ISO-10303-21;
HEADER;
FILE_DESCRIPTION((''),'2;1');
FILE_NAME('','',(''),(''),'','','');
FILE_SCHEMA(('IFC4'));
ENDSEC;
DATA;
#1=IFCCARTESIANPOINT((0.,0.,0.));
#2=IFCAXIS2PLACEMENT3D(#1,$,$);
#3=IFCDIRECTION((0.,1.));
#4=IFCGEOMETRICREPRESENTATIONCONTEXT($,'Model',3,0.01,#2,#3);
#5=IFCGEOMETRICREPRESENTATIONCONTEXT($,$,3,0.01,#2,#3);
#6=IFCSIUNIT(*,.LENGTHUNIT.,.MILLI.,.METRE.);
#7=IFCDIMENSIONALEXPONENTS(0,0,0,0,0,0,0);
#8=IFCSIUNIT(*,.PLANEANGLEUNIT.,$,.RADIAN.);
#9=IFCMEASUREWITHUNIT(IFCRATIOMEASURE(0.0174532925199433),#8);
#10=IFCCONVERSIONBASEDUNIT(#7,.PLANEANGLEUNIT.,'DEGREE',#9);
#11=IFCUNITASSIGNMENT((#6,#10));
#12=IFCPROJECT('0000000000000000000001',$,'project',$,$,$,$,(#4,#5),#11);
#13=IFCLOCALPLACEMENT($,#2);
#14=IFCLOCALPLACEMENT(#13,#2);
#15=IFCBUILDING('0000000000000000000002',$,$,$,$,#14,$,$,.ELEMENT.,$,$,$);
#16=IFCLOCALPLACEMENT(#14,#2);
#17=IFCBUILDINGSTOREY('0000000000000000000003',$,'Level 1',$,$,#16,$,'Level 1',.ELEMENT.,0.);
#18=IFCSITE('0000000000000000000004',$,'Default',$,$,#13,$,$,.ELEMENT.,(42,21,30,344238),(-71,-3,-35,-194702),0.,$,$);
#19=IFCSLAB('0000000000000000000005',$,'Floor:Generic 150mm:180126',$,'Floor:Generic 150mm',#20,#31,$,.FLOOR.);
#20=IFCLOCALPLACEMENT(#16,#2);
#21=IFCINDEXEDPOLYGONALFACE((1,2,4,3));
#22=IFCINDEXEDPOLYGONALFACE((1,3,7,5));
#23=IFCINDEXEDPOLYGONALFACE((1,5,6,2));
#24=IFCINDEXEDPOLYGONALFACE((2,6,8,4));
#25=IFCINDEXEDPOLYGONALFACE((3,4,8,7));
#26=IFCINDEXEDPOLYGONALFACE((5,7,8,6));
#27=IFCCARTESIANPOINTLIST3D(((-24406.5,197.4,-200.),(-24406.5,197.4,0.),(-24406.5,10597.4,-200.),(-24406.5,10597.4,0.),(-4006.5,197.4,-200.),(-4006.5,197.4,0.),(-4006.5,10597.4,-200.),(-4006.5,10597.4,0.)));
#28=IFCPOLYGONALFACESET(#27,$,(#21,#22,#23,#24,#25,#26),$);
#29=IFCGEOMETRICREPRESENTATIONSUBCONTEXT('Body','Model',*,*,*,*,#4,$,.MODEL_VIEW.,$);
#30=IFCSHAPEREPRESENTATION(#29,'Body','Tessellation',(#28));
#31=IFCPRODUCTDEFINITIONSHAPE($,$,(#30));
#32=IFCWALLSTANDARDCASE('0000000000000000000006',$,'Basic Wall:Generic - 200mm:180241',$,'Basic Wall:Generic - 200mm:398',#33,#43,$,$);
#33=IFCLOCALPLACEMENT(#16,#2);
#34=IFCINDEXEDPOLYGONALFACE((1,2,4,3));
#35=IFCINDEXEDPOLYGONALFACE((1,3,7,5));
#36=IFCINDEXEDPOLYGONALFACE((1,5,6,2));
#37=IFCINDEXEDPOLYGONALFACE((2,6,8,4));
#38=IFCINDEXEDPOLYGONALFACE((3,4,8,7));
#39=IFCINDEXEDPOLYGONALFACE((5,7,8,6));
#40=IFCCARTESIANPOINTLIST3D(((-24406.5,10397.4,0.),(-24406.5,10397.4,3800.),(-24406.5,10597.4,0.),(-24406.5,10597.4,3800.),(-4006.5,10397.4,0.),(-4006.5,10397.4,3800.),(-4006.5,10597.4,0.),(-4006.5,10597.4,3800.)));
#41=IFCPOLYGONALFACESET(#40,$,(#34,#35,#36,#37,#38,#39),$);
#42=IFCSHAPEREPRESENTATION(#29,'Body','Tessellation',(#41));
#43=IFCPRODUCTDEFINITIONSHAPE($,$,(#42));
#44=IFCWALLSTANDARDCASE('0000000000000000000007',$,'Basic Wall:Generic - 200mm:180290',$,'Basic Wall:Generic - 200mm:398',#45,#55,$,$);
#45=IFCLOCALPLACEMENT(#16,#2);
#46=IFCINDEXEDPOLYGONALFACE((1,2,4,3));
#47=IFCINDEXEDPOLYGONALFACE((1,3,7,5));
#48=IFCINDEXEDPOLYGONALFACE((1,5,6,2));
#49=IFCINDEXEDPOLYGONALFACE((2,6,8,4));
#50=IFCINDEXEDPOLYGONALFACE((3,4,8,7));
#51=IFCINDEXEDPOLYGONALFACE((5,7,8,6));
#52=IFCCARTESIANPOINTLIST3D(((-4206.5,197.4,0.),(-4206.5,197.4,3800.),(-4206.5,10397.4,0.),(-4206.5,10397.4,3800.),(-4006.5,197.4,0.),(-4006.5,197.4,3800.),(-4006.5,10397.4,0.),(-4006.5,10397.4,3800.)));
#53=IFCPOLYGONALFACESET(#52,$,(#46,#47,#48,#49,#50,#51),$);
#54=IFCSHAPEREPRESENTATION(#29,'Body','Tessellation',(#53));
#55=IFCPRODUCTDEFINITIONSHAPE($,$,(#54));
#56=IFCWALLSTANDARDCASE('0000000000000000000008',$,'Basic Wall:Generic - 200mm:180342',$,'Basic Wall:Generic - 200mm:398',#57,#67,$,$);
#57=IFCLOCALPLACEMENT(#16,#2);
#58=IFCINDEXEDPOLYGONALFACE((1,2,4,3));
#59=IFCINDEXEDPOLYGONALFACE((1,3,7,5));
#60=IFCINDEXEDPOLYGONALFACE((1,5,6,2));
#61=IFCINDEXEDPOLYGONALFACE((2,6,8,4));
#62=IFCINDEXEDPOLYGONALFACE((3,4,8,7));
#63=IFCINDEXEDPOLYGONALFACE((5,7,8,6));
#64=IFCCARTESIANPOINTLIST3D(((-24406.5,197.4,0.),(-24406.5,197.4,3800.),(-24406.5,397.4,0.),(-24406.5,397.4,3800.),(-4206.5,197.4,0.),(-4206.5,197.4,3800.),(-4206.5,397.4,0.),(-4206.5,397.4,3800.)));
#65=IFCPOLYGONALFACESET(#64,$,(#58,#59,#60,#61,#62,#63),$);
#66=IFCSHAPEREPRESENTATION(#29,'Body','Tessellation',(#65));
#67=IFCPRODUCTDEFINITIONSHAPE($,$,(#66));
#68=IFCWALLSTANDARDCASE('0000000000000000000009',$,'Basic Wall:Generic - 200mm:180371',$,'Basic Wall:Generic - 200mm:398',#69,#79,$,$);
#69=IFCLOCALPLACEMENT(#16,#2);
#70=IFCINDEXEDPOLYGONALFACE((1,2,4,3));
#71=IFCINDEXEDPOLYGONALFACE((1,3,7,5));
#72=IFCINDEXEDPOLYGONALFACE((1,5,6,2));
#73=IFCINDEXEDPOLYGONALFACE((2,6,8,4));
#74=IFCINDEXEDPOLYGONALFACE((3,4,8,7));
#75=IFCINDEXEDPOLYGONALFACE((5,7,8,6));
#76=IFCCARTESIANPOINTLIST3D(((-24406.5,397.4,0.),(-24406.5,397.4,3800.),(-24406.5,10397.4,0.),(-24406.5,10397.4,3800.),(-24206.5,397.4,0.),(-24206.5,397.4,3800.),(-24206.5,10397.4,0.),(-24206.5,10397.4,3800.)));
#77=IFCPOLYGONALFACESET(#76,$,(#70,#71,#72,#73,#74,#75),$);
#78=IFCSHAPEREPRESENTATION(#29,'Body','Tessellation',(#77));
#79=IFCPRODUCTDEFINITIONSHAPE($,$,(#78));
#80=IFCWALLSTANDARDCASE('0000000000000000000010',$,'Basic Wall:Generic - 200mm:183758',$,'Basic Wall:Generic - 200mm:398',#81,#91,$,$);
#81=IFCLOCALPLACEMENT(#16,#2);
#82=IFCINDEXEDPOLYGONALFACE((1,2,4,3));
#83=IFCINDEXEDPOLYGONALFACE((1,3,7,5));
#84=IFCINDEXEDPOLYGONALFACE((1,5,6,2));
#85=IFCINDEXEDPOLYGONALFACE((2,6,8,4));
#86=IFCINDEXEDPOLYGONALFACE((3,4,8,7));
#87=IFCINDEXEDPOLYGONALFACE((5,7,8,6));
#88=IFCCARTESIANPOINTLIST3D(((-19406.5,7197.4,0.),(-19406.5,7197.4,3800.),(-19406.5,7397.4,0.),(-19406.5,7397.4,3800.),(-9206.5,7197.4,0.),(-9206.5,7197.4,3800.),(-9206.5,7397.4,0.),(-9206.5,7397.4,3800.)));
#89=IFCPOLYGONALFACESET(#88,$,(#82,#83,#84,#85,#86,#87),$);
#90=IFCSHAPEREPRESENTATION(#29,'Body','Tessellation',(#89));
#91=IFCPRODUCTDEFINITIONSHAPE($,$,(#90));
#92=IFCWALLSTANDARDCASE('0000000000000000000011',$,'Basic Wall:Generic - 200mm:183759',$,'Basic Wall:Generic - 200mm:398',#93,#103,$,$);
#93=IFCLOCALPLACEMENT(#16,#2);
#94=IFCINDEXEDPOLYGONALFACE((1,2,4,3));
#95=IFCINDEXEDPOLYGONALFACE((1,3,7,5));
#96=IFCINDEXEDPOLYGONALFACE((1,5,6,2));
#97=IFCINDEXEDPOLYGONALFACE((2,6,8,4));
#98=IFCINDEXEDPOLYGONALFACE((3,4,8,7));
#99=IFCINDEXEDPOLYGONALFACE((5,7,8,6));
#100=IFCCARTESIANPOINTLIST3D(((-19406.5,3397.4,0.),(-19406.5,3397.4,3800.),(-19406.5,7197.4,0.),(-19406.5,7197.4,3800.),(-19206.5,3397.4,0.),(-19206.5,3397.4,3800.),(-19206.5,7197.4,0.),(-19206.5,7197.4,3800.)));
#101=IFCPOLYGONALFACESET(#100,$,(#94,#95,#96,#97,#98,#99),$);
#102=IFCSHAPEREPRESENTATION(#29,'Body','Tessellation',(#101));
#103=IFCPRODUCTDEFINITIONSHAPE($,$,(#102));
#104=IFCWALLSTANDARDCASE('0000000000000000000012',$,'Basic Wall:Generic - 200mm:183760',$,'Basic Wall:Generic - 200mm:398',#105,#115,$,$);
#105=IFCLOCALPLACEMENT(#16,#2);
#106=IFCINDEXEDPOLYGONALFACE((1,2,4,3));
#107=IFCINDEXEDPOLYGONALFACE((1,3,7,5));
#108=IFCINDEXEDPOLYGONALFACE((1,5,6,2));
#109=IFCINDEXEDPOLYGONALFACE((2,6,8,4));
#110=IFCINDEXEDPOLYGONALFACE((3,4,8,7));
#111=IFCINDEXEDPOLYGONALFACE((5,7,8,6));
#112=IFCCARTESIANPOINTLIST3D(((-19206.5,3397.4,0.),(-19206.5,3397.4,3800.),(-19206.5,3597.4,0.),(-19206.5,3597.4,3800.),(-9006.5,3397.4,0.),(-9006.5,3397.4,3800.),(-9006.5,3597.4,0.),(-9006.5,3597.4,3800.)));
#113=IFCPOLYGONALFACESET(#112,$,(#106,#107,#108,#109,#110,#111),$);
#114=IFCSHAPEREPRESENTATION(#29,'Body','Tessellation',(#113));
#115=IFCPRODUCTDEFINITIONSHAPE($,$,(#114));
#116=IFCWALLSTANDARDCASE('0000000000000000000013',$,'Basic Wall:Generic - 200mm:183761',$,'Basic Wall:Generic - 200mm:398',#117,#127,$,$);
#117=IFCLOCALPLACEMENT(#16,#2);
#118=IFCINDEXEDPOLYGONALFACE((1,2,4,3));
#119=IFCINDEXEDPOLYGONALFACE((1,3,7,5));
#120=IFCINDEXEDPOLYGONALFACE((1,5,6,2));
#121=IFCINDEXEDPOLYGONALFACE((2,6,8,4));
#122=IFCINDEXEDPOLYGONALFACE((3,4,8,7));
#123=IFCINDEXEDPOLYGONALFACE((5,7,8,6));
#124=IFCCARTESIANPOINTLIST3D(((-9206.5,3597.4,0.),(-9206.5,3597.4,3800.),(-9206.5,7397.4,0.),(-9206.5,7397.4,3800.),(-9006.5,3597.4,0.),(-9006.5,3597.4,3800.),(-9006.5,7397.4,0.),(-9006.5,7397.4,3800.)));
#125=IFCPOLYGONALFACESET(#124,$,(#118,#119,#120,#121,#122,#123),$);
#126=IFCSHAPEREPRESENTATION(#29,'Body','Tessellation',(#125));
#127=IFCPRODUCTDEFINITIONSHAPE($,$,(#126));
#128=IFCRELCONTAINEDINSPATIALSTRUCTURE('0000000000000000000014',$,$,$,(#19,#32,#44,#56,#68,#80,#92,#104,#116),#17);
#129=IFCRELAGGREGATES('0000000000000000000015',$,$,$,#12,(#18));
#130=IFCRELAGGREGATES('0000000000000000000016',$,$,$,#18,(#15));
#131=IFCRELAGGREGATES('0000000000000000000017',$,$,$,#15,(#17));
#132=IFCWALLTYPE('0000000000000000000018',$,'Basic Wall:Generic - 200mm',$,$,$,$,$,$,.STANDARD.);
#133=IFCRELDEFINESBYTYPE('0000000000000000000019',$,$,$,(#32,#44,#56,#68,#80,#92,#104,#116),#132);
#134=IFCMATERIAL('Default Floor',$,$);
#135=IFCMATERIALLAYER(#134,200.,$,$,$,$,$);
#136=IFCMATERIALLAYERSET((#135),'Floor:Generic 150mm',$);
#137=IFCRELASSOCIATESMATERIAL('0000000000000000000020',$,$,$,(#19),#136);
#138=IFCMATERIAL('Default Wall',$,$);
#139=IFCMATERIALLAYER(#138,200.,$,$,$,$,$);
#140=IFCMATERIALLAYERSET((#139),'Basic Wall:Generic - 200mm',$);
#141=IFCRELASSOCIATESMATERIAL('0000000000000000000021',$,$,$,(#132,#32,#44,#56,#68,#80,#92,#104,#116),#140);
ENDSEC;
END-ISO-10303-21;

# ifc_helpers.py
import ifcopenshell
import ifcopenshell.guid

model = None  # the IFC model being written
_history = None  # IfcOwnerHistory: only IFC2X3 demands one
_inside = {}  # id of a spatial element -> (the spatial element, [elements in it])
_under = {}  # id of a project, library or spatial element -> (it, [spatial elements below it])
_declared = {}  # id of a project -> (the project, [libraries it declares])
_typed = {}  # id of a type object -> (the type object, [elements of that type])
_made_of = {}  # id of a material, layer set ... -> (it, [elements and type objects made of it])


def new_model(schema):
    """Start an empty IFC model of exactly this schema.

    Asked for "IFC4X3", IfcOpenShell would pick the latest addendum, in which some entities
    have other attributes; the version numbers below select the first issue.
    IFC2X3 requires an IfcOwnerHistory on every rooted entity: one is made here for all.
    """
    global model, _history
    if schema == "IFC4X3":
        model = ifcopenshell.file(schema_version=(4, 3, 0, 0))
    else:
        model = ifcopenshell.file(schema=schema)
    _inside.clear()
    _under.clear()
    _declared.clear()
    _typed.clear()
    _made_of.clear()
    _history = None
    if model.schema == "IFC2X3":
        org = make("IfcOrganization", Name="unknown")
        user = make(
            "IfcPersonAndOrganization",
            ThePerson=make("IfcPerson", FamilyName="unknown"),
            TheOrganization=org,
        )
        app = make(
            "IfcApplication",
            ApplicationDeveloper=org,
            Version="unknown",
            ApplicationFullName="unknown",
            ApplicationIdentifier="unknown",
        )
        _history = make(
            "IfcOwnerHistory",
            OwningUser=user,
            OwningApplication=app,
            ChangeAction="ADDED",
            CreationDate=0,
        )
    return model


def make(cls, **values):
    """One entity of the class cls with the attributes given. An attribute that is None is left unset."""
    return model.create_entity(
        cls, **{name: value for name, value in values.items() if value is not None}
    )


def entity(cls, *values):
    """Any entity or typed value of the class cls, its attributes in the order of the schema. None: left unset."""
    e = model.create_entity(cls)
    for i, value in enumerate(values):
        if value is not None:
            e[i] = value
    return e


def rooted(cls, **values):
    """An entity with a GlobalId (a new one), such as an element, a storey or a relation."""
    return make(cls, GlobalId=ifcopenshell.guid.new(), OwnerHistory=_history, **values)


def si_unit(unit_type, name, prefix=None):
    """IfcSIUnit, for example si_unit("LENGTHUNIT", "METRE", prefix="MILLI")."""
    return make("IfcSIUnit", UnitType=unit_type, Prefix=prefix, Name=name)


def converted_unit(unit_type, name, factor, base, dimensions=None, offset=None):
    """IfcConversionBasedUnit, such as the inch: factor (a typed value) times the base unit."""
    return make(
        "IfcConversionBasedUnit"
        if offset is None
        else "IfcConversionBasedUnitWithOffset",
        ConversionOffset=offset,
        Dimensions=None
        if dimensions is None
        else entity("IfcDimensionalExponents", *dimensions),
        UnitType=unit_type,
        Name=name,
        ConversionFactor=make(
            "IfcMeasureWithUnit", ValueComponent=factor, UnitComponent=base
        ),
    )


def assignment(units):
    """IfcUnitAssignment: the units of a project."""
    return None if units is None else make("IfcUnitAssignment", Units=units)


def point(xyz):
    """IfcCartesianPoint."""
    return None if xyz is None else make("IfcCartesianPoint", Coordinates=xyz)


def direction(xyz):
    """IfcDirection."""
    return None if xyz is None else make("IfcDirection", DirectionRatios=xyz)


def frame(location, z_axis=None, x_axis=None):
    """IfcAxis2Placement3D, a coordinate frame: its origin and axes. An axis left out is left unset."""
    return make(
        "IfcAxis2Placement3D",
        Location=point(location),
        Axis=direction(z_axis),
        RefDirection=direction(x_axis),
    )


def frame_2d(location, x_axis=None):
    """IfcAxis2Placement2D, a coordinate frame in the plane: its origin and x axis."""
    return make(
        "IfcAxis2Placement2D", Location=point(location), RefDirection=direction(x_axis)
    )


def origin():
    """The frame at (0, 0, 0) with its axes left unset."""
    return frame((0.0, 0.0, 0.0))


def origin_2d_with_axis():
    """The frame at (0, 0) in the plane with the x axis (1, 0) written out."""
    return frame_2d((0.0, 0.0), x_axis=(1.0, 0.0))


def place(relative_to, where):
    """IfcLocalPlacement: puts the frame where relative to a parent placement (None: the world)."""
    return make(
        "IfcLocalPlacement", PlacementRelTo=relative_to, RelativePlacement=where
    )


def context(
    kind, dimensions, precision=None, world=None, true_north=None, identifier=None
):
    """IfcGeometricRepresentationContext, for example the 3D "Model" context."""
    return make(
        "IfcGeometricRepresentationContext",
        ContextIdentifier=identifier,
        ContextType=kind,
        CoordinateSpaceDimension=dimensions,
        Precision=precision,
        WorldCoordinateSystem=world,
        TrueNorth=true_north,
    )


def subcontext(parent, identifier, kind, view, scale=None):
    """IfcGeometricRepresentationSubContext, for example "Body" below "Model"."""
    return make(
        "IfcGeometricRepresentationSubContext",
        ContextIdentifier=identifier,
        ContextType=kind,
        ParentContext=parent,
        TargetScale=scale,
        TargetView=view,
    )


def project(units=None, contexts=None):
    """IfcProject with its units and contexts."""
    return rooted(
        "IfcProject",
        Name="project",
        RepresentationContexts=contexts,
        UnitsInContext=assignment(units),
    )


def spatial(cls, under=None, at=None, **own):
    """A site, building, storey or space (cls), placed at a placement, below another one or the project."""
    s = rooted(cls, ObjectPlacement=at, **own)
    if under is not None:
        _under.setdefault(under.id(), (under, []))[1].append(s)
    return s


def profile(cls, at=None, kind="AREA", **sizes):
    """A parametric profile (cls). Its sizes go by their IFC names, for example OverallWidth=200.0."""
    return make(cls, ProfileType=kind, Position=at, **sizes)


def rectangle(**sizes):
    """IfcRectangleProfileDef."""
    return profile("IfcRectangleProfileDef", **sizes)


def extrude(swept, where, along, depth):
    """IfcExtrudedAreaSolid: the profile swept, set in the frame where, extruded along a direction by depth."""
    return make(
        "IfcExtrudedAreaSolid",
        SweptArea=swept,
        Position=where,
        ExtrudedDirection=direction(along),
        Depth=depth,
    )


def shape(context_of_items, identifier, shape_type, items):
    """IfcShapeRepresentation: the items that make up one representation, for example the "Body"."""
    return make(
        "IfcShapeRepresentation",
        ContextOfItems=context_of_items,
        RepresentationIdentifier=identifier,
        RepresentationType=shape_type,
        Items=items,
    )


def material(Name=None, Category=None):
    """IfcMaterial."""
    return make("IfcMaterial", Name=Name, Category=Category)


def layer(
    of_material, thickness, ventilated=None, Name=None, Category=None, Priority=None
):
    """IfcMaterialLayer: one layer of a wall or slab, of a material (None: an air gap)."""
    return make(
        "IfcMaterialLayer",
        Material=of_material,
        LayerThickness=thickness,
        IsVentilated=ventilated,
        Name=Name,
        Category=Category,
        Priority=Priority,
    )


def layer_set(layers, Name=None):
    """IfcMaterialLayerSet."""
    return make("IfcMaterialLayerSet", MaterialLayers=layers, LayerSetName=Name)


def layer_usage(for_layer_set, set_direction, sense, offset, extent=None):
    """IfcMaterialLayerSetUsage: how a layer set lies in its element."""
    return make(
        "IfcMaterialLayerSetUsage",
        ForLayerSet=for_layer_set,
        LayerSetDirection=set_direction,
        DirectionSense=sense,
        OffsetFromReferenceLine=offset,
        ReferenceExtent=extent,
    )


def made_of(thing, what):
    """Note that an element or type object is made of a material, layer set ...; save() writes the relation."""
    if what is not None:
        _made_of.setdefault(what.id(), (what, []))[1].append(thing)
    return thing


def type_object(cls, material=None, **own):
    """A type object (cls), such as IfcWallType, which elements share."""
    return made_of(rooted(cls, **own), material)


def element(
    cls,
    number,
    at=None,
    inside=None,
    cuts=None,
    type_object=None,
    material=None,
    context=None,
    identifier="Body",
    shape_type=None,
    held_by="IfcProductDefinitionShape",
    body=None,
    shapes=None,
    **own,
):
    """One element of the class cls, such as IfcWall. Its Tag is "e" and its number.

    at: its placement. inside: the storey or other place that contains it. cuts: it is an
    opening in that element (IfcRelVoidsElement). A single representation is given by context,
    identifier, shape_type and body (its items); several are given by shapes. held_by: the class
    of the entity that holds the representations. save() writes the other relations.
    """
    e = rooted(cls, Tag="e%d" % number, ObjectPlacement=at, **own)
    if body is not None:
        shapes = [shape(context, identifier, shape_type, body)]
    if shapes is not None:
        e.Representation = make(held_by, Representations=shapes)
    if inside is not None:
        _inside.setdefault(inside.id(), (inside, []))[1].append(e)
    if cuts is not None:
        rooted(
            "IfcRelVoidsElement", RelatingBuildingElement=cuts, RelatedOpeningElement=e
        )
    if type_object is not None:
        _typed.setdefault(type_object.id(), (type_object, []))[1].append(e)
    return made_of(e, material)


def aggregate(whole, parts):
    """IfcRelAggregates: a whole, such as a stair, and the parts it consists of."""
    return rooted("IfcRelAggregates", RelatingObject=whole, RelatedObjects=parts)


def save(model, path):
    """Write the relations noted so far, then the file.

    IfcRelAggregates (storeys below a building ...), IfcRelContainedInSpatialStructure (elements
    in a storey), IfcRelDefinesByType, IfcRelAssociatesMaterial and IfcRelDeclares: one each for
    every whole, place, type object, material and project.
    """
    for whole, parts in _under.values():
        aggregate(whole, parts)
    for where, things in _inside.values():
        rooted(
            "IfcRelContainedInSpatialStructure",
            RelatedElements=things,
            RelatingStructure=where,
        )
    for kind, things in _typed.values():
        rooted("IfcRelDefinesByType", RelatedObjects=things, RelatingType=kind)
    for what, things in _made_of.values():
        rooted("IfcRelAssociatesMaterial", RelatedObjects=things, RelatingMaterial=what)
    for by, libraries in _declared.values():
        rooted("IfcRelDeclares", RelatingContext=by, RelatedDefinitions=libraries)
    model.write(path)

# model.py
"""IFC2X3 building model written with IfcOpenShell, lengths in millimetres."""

from ifc_helpers import new_model, entity, si_unit, converted_unit, direction, frame, frame_2d, origin, origin_2d_with_axis, place, context, subcontext, project, spatial, rectangle, extrude, material, layer, layer_set, layer_usage, type_object, element, save


model = new_model("IFC2X3")

# Units and contexts
model_context = context("Model", 3, precision=0.01, world=origin(), true_north=direction((0.0, 1.0)))
context_of_model = context(None, 3, precision=0.01, world=origin(), true_north=direction((0.0, 1.0)))
body_context = subcontext(model_context, "Body", "Model", "MODEL_VIEW")
ifc_project = project(units=[si_unit("LENGTHUNIT", "METRE", prefix="MILLI"), converted_unit("PLANEANGLEUNIT", "DEGREE", entity("IfcRatioMeasure", 0.0174532925199433), si_unit("PLANEANGLEUNIT", "RADIAN"), dimensions=[0, 0, 0, 0, 0, 0, 0])], contexts=[model_context, context_of_model])

# Site, building, storey
site_placement = place(None, origin())
site = spatial("IfcSite", under=ifc_project, at=site_placement, Name="Default", CompositionType="ELEMENT", RefLatitude=(42, 21, 30, 344238), RefLongitude=(-71, -3, -35, -194702), RefElevation=0.0)
building_placement = place(site_placement, origin())
building = spatial("IfcBuilding", under=site, at=building_placement, CompositionType="ELEMENT")
storey_placement = place(building_placement, origin())
storey = spatial("IfcBuildingStorey", under=building, at=storey_placement, Name="Level 1", LongName="Level 1", CompositionType="ELEMENT", Elevation=0.0)

# Slab
ifc_material_1 = material(Name="Default Floor")
ifc_layer_1 = layer(ifc_material_1, 200.0)
ifc_layer_set_1 = layer_set([ifc_layer_1], Name="Floor:Generic 150mm")
ifc_layer_usage_1 = layer_usage(ifc_layer_set_1, "AXIS3", "POSITIVE", 0.0)
slab_placement = place(storey_placement, origin())
element("IfcSlab", 1, at=slab_placement, inside=storey, material=ifc_layer_usage_1, Name="Floor:Generic 150mm:180126", ObjectType="Floor:Generic 150mm", PredefinedType="FLOOR", context=body_context, shape_type="SweptSolid", body=[
    extrude(rectangle(XDim=10400.0, YDim=20400.0, at=origin_2d_with_axis()), frame((-14206.5, 5397.4, 0.0), z_axis=(0.0, 0.0, -1.0), x_axis=(0.0, 1.0, 0.0)), (0.0, 0.0, 1.0), 200.0),
])

# Walls
ifc_material_2 = material(Name="Default Wall")
ifc_layer_2 = layer(ifc_material_2, 200.0)
ifc_layer_set_2 = layer_set([ifc_layer_2], Name="Basic Wall:Generic - 200mm")
ifc_layer_usage_2 = layer_usage(ifc_layer_set_2, "AXIS2", "NEGATIVE", 100.0)
wall_type = type_object("IfcWallType", Name="Basic Wall:Generic - 200mm", PredefinedType="STANDARD", material=ifc_layer_set_2)
wall_1_placement = place(storey_placement, frame((-24406.5, 10497.4, 0.0)))
element("IfcWallStandardCase", 2, at=wall_1_placement, inside=storey, type_object=wall_type, material=ifc_layer_usage_2, Name="Basic Wall:Generic - 200mm:180241", ObjectType="Basic Wall:Generic - 200mm:398", context=body_context, shape_type="SweptSolid", body=[
    extrude(rectangle(XDim=20400.0, YDim=200.0, at=frame_2d((10200.0, 0.0), x_axis=(-1.0, 0.0))), origin(), (0.0, 0.0, 1.0), 3800.0),
])
ifc_layer_usage_3 = layer_usage(ifc_layer_set_2, "AXIS2", "NEGATIVE", 100.0)
wall_2_placement = place(storey_placement, frame((-4106.5, 10397.4, 0.0), z_axis=(0.0, 0.0, 1.0), x_axis=(0.0, -1.0, 0.0)))
element("IfcWallStandardCase", 3, at=wall_2_placement, inside=storey, type_object=wall_type, material=ifc_layer_usage_3, Name="Basic Wall:Generic - 200mm:180290", ObjectType="Basic Wall:Generic - 200mm:398", context=body_context, shape_type="SweptSolid", body=[
    extrude(rectangle(XDim=10200.0, YDim=200.0, at=frame_2d((5100.0, 0.0), x_axis=(-1.0, 0.0))), origin(), (0.0, 0.0, 1.0), 3800.0),
])
ifc_layer_usage_4 = layer_usage(ifc_layer_set_2, "AXIS2", "NEGATIVE", 100.0)
wall_3_placement = place(storey_placement, frame((-4206.5, 297.4, 0.0), z_axis=(0.0, 0.0, 1.0), x_axis=(-1.0, 0.0, 0.0)))
element("IfcWallStandardCase", 4, at=wall_3_placement, inside=storey, type_object=wall_type, material=ifc_layer_usage_4, Name="Basic Wall:Generic - 200mm:180342", ObjectType="Basic Wall:Generic - 200mm:398", context=body_context, shape_type="SweptSolid", body=[
    extrude(rectangle(XDim=20200.0, YDim=200.0, at=frame_2d((10100.0, 0.0), x_axis=(-1.0, 0.0))), origin(), (0.0, 0.0, 1.0), 3800.0),
])
ifc_layer_usage_5 = layer_usage(ifc_layer_set_2, "AXIS2", "NEGATIVE", 100.0)
wall_4_placement = place(storey_placement, frame((-24306.5, 397.4, 0.0), z_axis=(0.0, 0.0, 1.0), x_axis=(0.0, 1.0, 0.0)))
element("IfcWallStandardCase", 5, at=wall_4_placement, inside=storey, type_object=wall_type, material=ifc_layer_usage_5, Name="Basic Wall:Generic - 200mm:180371", ObjectType="Basic Wall:Generic - 200mm:398", context=body_context, shape_type="SweptSolid", body=[
    extrude(rectangle(XDim=10000.0, YDim=200.0, at=frame_2d((5000.0, 0.0), x_axis=(-1.0, 0.0))), origin(), (0.0, 0.0, 1.0), 3800.0),
])
ifc_layer_usage_6 = layer_usage(ifc_layer_set_2, "AXIS2", "NEGATIVE", 100.0)
wall_5_placement = place(storey_placement, frame((-19406.5, 7297.4, 0.0)))
element("IfcWallStandardCase", 6, at=wall_5_placement, inside=storey, type_object=wall_type, material=ifc_layer_usage_6, Name="Basic Wall:Generic - 200mm:183758", ObjectType="Basic Wall:Generic - 200mm:398", context=body_context, shape_type="SweptSolid", body=[
    extrude(rectangle(XDim=10200.0, YDim=200.0, at=frame_2d((5100.0, 0.0), x_axis=(-1.0, 0.0))), origin(), (0.0, 0.0, 1.0), 3800.0),
])
ifc_layer_usage_7 = layer_usage(ifc_layer_set_2, "AXIS2", "NEGATIVE", 100.0)
wall_6_placement = place(storey_placement, frame((-19306.5, 3397.4, 0.0), z_axis=(0.0, 0.0, 1.0), x_axis=(0.0, 1.0, 0.0)))
element("IfcWallStandardCase", 7, at=wall_6_placement, inside=storey, type_object=wall_type, material=ifc_layer_usage_7, Name="Basic Wall:Generic - 200mm:183759", ObjectType="Basic Wall:Generic - 200mm:398", context=body_context, shape_type="SweptSolid", body=[
    extrude(rectangle(XDim=3800.0, YDim=200.0, at=frame_2d((1900.0, 0.0), x_axis=(-1.0, 0.0))), origin(), (0.0, 0.0, 1.0), 3800.0),
])
ifc_layer_usage_8 = layer_usage(ifc_layer_set_2, "AXIS2", "NEGATIVE", 100.0)
wall_7_placement = place(storey_placement, frame((-9006.5, 3497.4, 0.0), z_axis=(0.0, 0.0, 1.0), x_axis=(-1.0, 0.0, 0.0)))
element("IfcWallStandardCase", 8, at=wall_7_placement, inside=storey, type_object=wall_type, material=ifc_layer_usage_8, Name="Basic Wall:Generic - 200mm:183760", ObjectType="Basic Wall:Generic - 200mm:398", context=body_context, shape_type="SweptSolid", body=[
    extrude(rectangle(XDim=10200.0, YDim=200.0, at=frame_2d((5100.0, 0.0), x_axis=(-1.0, 0.0))), origin(), (0.0, 0.0, 1.0), 3800.0),
])
ifc_layer_usage_9 = layer_usage(ifc_layer_set_2, "AXIS2", "NEGATIVE", 100.0)
wall_8_placement = place(storey_placement, frame((-9106.5, 7397.4, 0.0), z_axis=(0.0, 0.0, 1.0), x_axis=(0.0, -1.0, 0.0)))
element("IfcWallStandardCase", 9, at=wall_8_placement, inside=storey, type_object=wall_type, material=ifc_layer_usage_9, Name="Basic Wall:Generic - 200mm:183761", ObjectType="Basic Wall:Generic - 200mm:398", context=body_context, shape_type="SweptSolid", body=[
    extrude(rectangle(XDim=3800.0, YDim=200.0, at=frame_2d((1900.0, 0.0), x_axis=(-1.0, 0.0))), origin(), (0.0, 0.0, 1.0), 3800.0),
])

save(model, "model.ifc")
